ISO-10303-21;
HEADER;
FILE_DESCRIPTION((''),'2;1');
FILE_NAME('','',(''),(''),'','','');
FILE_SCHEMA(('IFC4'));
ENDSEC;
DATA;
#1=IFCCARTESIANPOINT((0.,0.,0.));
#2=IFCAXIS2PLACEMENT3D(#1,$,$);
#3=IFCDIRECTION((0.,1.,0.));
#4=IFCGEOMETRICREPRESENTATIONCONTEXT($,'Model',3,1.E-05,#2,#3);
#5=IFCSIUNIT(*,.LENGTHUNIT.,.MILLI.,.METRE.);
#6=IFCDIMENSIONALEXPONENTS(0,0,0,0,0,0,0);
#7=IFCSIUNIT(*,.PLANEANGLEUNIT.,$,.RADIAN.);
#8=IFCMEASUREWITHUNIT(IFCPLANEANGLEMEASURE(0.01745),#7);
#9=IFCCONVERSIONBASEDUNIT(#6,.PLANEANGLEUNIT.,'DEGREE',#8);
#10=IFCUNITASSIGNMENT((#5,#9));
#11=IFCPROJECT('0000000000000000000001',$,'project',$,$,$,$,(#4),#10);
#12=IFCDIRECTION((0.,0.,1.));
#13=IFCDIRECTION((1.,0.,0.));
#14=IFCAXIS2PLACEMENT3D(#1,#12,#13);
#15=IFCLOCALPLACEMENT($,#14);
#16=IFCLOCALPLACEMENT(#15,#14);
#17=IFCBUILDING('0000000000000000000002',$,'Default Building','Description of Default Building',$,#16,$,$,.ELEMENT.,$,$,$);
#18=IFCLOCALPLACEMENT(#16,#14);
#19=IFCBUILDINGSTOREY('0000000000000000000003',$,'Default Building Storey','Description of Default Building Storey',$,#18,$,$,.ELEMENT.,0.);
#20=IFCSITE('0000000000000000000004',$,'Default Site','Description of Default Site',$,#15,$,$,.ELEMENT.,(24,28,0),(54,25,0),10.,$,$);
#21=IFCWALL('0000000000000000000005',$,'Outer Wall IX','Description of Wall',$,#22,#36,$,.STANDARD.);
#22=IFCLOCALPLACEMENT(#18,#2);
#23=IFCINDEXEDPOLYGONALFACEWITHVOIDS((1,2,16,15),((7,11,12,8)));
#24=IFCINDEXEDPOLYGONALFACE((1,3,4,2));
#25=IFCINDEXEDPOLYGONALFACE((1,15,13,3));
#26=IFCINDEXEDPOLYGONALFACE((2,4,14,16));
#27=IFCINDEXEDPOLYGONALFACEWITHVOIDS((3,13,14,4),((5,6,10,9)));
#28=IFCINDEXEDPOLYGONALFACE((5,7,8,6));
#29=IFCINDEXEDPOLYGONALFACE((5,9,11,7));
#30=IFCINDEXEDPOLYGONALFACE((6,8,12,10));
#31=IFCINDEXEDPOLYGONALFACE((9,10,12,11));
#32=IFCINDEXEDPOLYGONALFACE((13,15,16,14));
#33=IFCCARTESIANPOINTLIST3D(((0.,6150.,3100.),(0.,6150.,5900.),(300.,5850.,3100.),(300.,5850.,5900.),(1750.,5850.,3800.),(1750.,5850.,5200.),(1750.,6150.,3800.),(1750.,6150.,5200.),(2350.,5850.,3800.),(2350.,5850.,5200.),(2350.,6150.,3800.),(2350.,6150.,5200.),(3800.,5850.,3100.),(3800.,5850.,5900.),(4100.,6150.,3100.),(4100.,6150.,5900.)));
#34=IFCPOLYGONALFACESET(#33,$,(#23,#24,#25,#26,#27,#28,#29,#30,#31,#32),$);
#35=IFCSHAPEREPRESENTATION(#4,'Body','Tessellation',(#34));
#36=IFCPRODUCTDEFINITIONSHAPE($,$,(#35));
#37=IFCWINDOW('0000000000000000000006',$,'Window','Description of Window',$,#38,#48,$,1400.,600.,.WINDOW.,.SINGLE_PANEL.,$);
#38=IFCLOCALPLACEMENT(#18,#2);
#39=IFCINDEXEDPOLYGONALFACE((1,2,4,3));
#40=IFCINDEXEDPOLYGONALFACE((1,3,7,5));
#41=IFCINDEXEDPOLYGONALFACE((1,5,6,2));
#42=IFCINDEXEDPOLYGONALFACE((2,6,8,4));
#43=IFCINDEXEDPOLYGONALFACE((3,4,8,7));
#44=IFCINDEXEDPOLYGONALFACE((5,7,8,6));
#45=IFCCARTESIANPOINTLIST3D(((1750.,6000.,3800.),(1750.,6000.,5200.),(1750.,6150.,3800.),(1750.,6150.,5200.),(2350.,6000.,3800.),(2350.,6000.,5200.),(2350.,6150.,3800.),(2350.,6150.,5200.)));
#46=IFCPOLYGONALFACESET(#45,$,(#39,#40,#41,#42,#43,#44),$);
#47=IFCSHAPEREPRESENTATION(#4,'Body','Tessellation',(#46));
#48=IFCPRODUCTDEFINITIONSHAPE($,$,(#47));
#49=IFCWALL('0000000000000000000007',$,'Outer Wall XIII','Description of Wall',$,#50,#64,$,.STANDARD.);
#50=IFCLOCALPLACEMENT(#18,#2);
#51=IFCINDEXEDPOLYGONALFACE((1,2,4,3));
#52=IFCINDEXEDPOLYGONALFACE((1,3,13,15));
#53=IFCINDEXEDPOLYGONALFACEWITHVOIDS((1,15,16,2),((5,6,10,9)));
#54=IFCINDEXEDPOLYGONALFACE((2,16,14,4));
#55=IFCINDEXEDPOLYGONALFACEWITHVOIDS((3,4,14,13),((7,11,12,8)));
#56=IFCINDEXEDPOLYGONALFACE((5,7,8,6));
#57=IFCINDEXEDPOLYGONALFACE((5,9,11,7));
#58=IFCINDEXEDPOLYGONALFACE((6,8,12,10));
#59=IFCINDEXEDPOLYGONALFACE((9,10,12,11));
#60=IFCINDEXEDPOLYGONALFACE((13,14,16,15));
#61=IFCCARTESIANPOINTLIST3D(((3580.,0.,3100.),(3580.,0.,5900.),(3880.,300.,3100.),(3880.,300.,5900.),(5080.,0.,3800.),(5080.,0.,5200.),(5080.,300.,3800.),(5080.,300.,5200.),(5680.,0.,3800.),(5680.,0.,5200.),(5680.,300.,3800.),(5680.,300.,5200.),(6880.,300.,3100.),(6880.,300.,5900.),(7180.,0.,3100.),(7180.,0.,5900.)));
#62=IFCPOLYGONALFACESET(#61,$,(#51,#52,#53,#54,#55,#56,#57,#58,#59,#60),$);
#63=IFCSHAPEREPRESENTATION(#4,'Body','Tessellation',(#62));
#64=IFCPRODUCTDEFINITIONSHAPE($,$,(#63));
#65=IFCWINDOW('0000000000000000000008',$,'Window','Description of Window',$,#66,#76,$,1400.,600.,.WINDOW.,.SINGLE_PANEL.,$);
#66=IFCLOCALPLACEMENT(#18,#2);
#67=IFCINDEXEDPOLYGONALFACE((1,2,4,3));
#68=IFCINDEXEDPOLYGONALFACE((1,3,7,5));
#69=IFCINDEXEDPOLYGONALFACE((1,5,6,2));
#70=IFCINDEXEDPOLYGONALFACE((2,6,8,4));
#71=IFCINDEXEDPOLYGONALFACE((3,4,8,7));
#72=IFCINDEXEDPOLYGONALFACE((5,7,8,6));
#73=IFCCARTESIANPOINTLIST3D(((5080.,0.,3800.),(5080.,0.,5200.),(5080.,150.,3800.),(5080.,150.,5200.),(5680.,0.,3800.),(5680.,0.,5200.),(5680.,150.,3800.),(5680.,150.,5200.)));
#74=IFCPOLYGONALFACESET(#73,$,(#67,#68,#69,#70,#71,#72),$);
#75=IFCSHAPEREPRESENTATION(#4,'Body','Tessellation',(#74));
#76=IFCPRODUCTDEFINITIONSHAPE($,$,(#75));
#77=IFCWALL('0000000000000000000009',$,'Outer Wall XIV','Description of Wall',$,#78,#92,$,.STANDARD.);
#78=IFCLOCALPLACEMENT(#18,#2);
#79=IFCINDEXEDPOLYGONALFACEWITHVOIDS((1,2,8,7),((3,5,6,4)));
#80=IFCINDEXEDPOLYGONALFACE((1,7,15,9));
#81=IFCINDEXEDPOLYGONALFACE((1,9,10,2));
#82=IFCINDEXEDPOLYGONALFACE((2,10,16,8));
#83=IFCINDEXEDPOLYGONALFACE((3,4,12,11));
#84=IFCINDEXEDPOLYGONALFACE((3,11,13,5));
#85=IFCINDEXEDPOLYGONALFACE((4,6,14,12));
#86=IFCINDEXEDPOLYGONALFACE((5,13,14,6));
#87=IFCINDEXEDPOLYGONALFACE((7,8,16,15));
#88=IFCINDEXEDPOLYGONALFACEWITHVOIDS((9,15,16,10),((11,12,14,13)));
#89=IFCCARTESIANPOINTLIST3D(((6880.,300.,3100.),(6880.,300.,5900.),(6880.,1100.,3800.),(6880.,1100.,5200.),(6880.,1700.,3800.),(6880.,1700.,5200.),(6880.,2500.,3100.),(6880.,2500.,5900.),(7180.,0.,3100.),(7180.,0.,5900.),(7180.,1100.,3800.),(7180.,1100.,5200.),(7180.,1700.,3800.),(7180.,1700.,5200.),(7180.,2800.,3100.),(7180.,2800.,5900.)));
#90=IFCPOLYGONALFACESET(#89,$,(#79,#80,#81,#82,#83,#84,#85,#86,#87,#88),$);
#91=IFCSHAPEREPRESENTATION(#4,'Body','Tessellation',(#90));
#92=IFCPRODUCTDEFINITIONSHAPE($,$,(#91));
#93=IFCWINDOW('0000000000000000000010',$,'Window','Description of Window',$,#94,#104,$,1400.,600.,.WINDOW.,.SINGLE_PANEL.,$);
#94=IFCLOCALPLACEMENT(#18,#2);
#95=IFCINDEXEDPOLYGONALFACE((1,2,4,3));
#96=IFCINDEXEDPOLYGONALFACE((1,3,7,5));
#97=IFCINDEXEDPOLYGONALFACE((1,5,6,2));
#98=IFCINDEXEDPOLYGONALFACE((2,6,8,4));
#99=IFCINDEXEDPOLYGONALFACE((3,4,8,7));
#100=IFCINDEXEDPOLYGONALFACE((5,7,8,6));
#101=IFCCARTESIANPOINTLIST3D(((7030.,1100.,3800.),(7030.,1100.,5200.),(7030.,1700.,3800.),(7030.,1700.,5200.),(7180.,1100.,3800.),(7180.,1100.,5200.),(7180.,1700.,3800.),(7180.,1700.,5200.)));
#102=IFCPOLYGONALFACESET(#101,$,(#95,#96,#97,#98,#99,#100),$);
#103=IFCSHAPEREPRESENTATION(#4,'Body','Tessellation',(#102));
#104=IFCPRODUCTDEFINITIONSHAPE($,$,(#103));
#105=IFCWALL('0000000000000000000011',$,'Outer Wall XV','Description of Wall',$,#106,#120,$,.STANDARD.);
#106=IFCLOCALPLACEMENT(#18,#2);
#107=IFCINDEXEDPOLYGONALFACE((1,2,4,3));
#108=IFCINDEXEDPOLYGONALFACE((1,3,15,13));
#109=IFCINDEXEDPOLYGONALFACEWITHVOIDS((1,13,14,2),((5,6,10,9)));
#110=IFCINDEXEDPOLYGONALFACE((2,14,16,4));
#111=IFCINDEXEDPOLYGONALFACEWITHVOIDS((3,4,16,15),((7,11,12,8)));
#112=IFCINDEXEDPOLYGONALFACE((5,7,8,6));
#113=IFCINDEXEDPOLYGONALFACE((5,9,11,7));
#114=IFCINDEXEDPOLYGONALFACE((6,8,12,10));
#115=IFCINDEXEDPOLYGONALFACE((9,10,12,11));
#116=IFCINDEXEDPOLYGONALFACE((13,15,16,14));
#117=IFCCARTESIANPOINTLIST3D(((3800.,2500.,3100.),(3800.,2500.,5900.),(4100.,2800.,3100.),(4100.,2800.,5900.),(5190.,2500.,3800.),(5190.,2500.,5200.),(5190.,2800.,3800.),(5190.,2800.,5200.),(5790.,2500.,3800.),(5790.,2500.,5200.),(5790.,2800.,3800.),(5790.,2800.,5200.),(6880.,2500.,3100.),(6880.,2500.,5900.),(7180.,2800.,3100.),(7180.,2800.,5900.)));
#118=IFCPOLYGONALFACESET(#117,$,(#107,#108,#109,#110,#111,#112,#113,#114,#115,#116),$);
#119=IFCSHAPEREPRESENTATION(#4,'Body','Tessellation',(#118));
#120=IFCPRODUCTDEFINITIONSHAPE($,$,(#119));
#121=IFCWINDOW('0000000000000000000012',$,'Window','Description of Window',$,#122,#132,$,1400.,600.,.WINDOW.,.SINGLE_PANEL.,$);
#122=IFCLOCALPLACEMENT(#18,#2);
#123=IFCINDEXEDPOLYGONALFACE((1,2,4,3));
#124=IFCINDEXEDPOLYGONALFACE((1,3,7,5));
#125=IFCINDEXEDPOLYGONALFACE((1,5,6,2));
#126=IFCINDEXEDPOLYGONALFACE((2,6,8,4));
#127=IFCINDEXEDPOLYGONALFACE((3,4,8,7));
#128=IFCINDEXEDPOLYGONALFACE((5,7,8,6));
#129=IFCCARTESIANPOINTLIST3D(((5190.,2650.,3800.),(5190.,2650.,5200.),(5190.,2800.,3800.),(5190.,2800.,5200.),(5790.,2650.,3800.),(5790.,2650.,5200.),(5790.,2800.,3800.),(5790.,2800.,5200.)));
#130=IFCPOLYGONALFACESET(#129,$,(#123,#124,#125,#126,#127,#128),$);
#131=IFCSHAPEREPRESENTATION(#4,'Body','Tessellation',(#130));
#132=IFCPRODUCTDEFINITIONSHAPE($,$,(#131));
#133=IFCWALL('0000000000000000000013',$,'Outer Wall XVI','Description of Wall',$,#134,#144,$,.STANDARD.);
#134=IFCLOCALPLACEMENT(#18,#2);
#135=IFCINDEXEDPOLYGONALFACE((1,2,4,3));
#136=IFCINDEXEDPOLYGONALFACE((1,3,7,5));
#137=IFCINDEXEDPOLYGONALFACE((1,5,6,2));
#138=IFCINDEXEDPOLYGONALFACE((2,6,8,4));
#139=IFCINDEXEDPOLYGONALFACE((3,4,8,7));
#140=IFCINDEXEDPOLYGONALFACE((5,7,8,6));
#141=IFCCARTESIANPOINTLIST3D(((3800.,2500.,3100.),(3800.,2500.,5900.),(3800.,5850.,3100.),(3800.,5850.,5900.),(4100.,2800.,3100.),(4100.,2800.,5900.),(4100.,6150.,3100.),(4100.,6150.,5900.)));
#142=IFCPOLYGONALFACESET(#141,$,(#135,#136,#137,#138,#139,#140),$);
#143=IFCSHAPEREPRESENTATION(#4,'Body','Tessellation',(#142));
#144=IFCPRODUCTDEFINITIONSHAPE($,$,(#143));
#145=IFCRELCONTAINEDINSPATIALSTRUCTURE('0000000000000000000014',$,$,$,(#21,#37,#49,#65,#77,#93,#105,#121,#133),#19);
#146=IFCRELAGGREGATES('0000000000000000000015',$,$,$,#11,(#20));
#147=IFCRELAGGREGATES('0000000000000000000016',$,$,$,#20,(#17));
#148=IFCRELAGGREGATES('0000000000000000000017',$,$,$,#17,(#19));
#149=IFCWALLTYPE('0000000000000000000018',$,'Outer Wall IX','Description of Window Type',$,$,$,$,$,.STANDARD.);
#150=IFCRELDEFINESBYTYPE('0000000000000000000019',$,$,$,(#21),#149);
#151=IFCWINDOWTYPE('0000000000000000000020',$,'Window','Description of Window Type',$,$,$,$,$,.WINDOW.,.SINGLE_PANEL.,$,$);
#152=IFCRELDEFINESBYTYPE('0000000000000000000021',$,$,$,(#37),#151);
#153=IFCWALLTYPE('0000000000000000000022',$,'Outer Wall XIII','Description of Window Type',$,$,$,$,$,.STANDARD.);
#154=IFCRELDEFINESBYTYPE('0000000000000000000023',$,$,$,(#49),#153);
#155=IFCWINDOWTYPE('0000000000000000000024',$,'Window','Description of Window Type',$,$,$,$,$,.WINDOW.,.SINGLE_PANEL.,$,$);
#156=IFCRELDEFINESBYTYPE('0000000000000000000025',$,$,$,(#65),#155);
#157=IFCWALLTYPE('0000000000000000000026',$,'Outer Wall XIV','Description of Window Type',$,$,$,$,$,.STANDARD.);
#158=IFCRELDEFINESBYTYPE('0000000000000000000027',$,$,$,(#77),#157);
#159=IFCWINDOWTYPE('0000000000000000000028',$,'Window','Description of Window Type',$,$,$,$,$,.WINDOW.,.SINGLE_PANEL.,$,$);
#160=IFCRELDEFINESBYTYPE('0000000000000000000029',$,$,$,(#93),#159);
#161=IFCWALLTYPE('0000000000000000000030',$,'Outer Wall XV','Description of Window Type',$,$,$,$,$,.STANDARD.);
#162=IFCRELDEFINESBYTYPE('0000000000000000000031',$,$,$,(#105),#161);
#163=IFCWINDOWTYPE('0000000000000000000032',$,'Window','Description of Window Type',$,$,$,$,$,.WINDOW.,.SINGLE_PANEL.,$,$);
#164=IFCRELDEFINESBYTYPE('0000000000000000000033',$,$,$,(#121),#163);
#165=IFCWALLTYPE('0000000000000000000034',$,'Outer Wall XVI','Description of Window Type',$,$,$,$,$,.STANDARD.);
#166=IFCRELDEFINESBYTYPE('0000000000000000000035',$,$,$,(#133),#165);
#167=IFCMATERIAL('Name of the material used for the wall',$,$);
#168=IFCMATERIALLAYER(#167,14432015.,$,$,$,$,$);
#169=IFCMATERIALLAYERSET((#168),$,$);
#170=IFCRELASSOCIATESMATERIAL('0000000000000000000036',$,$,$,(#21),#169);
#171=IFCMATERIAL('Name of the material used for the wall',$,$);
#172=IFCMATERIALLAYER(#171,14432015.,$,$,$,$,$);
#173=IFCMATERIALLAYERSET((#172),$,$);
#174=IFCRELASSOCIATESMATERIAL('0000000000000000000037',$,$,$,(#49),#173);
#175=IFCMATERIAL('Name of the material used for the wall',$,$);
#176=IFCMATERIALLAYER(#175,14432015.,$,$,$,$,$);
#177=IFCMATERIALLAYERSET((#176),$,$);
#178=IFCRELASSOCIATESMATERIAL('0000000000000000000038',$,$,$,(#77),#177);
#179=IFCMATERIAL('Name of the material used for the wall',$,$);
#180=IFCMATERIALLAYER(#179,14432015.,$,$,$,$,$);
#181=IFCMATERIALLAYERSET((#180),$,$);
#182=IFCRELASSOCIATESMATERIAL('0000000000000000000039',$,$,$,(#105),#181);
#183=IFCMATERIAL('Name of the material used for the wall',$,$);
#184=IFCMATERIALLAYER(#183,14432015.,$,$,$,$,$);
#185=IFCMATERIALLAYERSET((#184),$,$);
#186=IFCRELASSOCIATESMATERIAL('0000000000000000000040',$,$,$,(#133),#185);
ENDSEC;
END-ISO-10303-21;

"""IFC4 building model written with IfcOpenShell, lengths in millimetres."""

from ifc_helpers import new_model, entity, si_unit, converted_unit, direction, frame, origin, origin_with_axes, place, context, project, spatial, polyline, outline, extrude, material, layer, layer_set, layer_usage, type_object, element, fill, save


model = new_model("IFC4")

# Units and contexts
model_context = context("Model", 3, precision=1e-05, world=origin(), true_north=direction((0.0, 1.0, 0.0)))
ifc_project = project(units=[si_unit("LENGTHUNIT", "METRE", prefix="MILLI"), converted_unit("PLANEANGLEUNIT", "DEGREE", entity("IfcPlaneAngleMeasure", 0.01745), si_unit("PLANEANGLEUNIT", "RADIAN"), dimensions=[0, 0, 0, 0, 0, 0, 0])], contexts=[model_context])

# Site, building, storey
site_placement = place(None, origin_with_axes())
site = spatial("IfcSite", under=ifc_project, at=site_placement, Name="Default Site", Description="Description of Default Site", CompositionType="ELEMENT", RefLatitude=(24, 28, 0), RefLongitude=(54, 25, 0), RefElevation=10.0)
building_placement = place(site_placement, origin_with_axes())
building = spatial("IfcBuilding", under=site, at=building_placement, Name="Default Building", Description="Description of Default Building", CompositionType="ELEMENT")
storey_placement = place(building_placement, origin_with_axes())
storey = spatial("IfcBuildingStorey", under=building, at=storey_placement, Name="Default Building Storey", Description="Description of Default Building Storey", CompositionType="ELEMENT", Elevation=0.0)

# Walls, openings, windows
ifc_material_1 = material(Name="Name of the material used for the wall")
ifc_layer_1 = layer(ifc_material_1, 14432015.0)
ifc_layer_set_1 = layer_set([ifc_layer_1])
ifc_layer_usage_1 = layer_usage(ifc_layer_set_1, "AXIS2", "POSITIVE", -7216007.5)
wall_type_1 = type_object("IfcWallType", Name="Outer Wall IX", Description="Description of Window Type", PredefinedType="STANDARD")
wall_1_placement = place(storey_placement, frame((3950.0, 6000.0, 3100.0), z_axis=(0.0, 0.0, 1.0), x_axis=(-1.0, 0.0, 0.0)))
wall_1 = element("IfcWall", 1, at=wall_1_placement, inside=storey, type_object=wall_type_1, material=ifc_layer_usage_1, Name="Outer Wall IX", Description="Description of Wall", PredefinedType="STANDARD", context=model_context, shape_type="SweptSolid", body=[
    extrude(outline(polyline([(-150.0, -150.0), (150.0, 150.0), (3650.0, 150.0), (3950.0, -150.0), (-150.0, -150.0)])), origin_with_axes(), (0.0, 0.0, 1.0), 2800.0),
])
opening_1_placement = place(wall_1_placement, frame((1600.0, -150.0, 700.0), z_axis=(0.0, 0.0, 1.0), x_axis=(1.0, 0.0, 0.0)))
opening_1 = element("IfcOpeningElement", 2, at=opening_1_placement, cuts=wall_1, context=model_context, shape_type="SweptSolid", body=[
    extrude(outline(polyline([(0.0, 0.0), (0.0, 300.0), (600.0, 300.0), (600.0, 0.0), (0.0, 0.0)])), origin_with_axes(), (0.0, 0.0, 1.0), 1400.0),
])
window_type_1 = type_object("IfcWindowType", Name="Window", Description="Description of Window Type", PartitioningType="SINGLE_PANEL", PredefinedType="WINDOW")
window_1_placement = place(opening_1_placement, origin_with_axes())
window_1 = element("IfcWindow", 3, at=window_1_placement, inside=storey, type_object=window_type_1, Name="Window", Description="Description of Window", OverallHeight=1400.0, OverallWidth=600.0, PartitioningType="SINGLE_PANEL", PredefinedType="WINDOW", context=model_context, shape_type="SweptSolid", body=[
    extrude(outline(polyline([(0.0, 0.0), (0.0, 150.0), (600.0, 150.0), (600.0, 0.0), (0.0, 0.0)])), origin_with_axes(), (0.0, 0.0, 1.0), 1400.0),
])
fill(opening_1, window_1)
ifc_material_2 = material(Name="Name of the material used for the wall")
ifc_layer_2 = layer(ifc_material_2, 14432015.0)
ifc_layer_set_2 = layer_set([ifc_layer_2])
ifc_layer_usage_2 = layer_usage(ifc_layer_set_2, "AXIS2", "POSITIVE", -7216007.5)
wall_type_2 = type_object("IfcWallType", Name="Outer Wall XIII", Description="Description of Window Type", PredefinedType="STANDARD")
wall_2_placement = place(storey_placement, frame((3730.0, 150.0, 3100.0), z_axis=(0.0, 0.0, 1.0), x_axis=(1.0, 0.0, 0.0)))
wall_2 = element("IfcWall", 4, at=wall_2_placement, inside=storey, type_object=wall_type_2, material=ifc_layer_usage_2, Name="Outer Wall XIII", Description="Description of Wall", PredefinedType="STANDARD", context=model_context, shape_type="SweptSolid", body=[
    extrude(outline(polyline([(-150.0, -150.0), (150.0, 150.0), (3150.0, 150.0), (3450.0, -150.0), (-150.0, -150.0)])), origin_with_axes(), (0.0, 0.0, 1.0), 2800.0),
])
opening_2_placement = place(wall_2_placement, frame((1350.0, -150.0, 700.0), z_axis=(0.0, 0.0, 1.0), x_axis=(1.0, 0.0, 0.0)))
opening_2 = element("IfcOpeningElement", 5, at=opening_2_placement, cuts=wall_2, context=model_context, shape_type="SweptSolid", body=[
    extrude(outline(polyline([(0.0, 0.0), (0.0, 300.0), (600.0, 300.0), (600.0, 0.0), (0.0, 0.0)])), origin_with_axes(), (0.0, 0.0, 1.0), 1400.0),
])
window_type_2 = type_object("IfcWindowType", Name="Window", Description="Description of Window Type", PartitioningType="SINGLE_PANEL", PredefinedType="WINDOW")
window_2_placement = place(opening_2_placement, origin_with_axes())
window_2 = element("IfcWindow", 6, at=window_2_placement, inside=storey, type_object=window_type_2, Name="Window", Description="Description of Window", OverallHeight=1400.0, OverallWidth=600.0, PartitioningType="SINGLE_PANEL", PredefinedType="WINDOW", context=model_context, shape_type="SweptSolid", body=[
    extrude(outline(polyline([(0.0, 0.0), (0.0, 150.0), (600.0, 150.0), (600.0, 0.0), (0.0, 0.0)])), origin_with_axes(), (0.0, 0.0, 1.0), 1400.0),
])
fill(opening_2, window_2)
ifc_material_3 = material(Name="Name of the material used for the wall")
ifc_layer_3 = layer(ifc_material_3, 14432015.0)
ifc_layer_set_3 = layer_set([ifc_layer_3])
ifc_layer_usage_3 = layer_usage(ifc_layer_set_3, "AXIS2", "POSITIVE", -7216007.5)
wall_type_3 = type_object("IfcWallType", Name="Outer Wall XIV", Description="Description of Window Type", PredefinedType="STANDARD")
wall_3_placement = place(storey_placement, frame((7030.0, 150.0, 3100.0), z_axis=(0.0, 0.0, 1.0), x_axis=(0.0, 1.0, 0.0)))
wall_3 = element("IfcWall", 7, at=wall_3_placement, inside=storey, type_object=wall_type_3, material=ifc_layer_usage_3, Name="Outer Wall XIV", Description="Description of Wall", PredefinedType="STANDARD", context=model_context, shape_type="SweptSolid", body=[
    extrude(outline(polyline([(-150.0, -150.0), (150.0, 150.0), (2350.0, 150.0), (2650.0, -150.0), (-150.0, -150.0)])), origin_with_axes(), (0.0, 0.0, 1.0), 2800.0),
])
opening_3_placement = place(wall_3_placement, frame((950.0, -150.0, 700.0), z_axis=(0.0, 0.0, 1.0), x_axis=(1.0, 0.0, 0.0)))
opening_3 = element("IfcOpeningElement", 8, at=opening_3_placement, cuts=wall_3, context=model_context, shape_type="SweptSolid", body=[
    extrude(outline(polyline([(0.0, 0.0), (0.0, 300.0), (600.0, 300.0), (600.0, 0.0), (0.0, 0.0)])), origin_with_axes(), (0.0, 0.0, 1.0), 1400.0),
])
window_type_3 = type_object("IfcWindowType", Name="Window", Description="Description of Window Type", PartitioningType="SINGLE_PANEL", PredefinedType="WINDOW")
window_3_placement = place(opening_3_placement, origin_with_axes())
window_3 = element("IfcWindow", 9, at=window_3_placement, inside=storey, type_object=window_type_3, Name="Window", Description="Description of Window", OverallHeight=1400.0, OverallWidth=600.0, PartitioningType="SINGLE_PANEL", PredefinedType="WINDOW", context=model_context, shape_type="SweptSolid", body=[
    extrude(outline(polyline([(0.0, 0.0), (0.0, 150.0), (600.0, 150.0), (600.0, 0.0), (0.0, 0.0)])), origin_with_axes(), (0.0, 0.0, 1.0), 1400.0),
])
fill(opening_3, window_3)
ifc_material_4 = material(Name="Name of the material used for the wall")
ifc_layer_4 = layer(ifc_material_4, 14432015.0)
ifc_layer_set_4 = layer_set([ifc_layer_4])
ifc_layer_usage_4 = layer_usage(ifc_layer_set_4, "AXIS2", "POSITIVE", -7216007.5)
wall_type_4 = type_object("IfcWallType", Name="Outer Wall XV", Description="Description of Window Type", PredefinedType="STANDARD")
wall_4_placement = place(storey_placement, frame((7030.0, 2650.0, 3100.0), z_axis=(0.0, 0.0, 1.0), x_axis=(-1.0, 0.0, 0.0)))
wall_4 = element("IfcWall", 10, at=wall_4_placement, inside=storey, type_object=wall_type_4, material=ifc_layer_usage_4, Name="Outer Wall XV", Description="Description of Wall", PredefinedType="STANDARD", context=model_context, shape_type="SweptSolid", body=[
    extrude(outline(polyline([(-150.0, -150.0), (150.0, 150.0), (3230.0, 150.0), (2930.0, -150.0), (-150.0, -150.0)])), origin_with_axes(), (0.0, 0.0, 1.0), 2800.0),
])
opening_4_placement = place(wall_4_placement, frame((1240.0, -150.0, 700.0), z_axis=(0.0, 0.0, 1.0), x_axis=(1.0, 0.0, 0.0)))
opening_4 = element("IfcOpeningElement", 11, at=opening_4_placement, cuts=wall_4, context=model_context, shape_type="SweptSolid", body=[
    extrude(outline(polyline([(0.0, 0.0), (0.0, 300.0), (600.0, 300.0), (600.0, 0.0), (0.0, 0.0)])), origin_with_axes(), (0.0, 0.0, 1.0), 1400.0),
])
window_type_4 = type_object("IfcWindowType", Name="Window", Description="Description of Window Type", PartitioningType="SINGLE_PANEL", PredefinedType="WINDOW")
window_4_placement = place(opening_4_placement, origin_with_axes())
window_4 = element("IfcWindow", 12, at=window_4_placement, inside=storey, type_object=window_type_4, Name="Window", Description="Description of Window", OverallHeight=1400.0, OverallWidth=600.0, PartitioningType="SINGLE_PANEL", PredefinedType="WINDOW", context=model_context, shape_type="SweptSolid", body=[
    extrude(outline(polyline([(0.0, 0.0), (0.0, 150.0), (600.0, 150.0), (600.0, 0.0), (0.0, 0.0)])), origin_with_axes(), (0.0, 0.0, 1.0), 1400.0),
])
fill(opening_4, window_4)

# Wall
ifc_material_5 = material(Name="Name of the material used for the wall")
ifc_layer_5 = layer(ifc_material_5, 14432015.0)
ifc_layer_set_5 = layer_set([ifc_layer_5])
ifc_layer_usage_5 = layer_usage(ifc_layer_set_5, "AXIS2", "POSITIVE", -7216007.5)
wall_type_5 = type_object("IfcWallType", Name="Outer Wall XVI", Description="Description of Window Type", PredefinedType="STANDARD")
wall_5_placement = place(storey_placement, frame((3950.0, 2650.0, 3100.0), z_axis=(0.0, 0.0, 1.0), x_axis=(0.0, 1.0, 0.0)))
element("IfcWall", 13, at=wall_5_placement, inside=storey, type_object=wall_type_5, material=ifc_layer_usage_5, Name="Outer Wall XVI", Description="Description of Wall", PredefinedType="STANDARD", context=model_context, shape_type="SweptSolid", body=[
    extrude(outline(polyline([(150.0, -150.0), (-150.0, 150.0), (3200.0, 150.0), (3500.0, -150.0), (150.0, -150.0)])), origin_with_axes(), (0.0, 0.0, 1.0), 2800.0),
])

save(model, "model.ifc")
